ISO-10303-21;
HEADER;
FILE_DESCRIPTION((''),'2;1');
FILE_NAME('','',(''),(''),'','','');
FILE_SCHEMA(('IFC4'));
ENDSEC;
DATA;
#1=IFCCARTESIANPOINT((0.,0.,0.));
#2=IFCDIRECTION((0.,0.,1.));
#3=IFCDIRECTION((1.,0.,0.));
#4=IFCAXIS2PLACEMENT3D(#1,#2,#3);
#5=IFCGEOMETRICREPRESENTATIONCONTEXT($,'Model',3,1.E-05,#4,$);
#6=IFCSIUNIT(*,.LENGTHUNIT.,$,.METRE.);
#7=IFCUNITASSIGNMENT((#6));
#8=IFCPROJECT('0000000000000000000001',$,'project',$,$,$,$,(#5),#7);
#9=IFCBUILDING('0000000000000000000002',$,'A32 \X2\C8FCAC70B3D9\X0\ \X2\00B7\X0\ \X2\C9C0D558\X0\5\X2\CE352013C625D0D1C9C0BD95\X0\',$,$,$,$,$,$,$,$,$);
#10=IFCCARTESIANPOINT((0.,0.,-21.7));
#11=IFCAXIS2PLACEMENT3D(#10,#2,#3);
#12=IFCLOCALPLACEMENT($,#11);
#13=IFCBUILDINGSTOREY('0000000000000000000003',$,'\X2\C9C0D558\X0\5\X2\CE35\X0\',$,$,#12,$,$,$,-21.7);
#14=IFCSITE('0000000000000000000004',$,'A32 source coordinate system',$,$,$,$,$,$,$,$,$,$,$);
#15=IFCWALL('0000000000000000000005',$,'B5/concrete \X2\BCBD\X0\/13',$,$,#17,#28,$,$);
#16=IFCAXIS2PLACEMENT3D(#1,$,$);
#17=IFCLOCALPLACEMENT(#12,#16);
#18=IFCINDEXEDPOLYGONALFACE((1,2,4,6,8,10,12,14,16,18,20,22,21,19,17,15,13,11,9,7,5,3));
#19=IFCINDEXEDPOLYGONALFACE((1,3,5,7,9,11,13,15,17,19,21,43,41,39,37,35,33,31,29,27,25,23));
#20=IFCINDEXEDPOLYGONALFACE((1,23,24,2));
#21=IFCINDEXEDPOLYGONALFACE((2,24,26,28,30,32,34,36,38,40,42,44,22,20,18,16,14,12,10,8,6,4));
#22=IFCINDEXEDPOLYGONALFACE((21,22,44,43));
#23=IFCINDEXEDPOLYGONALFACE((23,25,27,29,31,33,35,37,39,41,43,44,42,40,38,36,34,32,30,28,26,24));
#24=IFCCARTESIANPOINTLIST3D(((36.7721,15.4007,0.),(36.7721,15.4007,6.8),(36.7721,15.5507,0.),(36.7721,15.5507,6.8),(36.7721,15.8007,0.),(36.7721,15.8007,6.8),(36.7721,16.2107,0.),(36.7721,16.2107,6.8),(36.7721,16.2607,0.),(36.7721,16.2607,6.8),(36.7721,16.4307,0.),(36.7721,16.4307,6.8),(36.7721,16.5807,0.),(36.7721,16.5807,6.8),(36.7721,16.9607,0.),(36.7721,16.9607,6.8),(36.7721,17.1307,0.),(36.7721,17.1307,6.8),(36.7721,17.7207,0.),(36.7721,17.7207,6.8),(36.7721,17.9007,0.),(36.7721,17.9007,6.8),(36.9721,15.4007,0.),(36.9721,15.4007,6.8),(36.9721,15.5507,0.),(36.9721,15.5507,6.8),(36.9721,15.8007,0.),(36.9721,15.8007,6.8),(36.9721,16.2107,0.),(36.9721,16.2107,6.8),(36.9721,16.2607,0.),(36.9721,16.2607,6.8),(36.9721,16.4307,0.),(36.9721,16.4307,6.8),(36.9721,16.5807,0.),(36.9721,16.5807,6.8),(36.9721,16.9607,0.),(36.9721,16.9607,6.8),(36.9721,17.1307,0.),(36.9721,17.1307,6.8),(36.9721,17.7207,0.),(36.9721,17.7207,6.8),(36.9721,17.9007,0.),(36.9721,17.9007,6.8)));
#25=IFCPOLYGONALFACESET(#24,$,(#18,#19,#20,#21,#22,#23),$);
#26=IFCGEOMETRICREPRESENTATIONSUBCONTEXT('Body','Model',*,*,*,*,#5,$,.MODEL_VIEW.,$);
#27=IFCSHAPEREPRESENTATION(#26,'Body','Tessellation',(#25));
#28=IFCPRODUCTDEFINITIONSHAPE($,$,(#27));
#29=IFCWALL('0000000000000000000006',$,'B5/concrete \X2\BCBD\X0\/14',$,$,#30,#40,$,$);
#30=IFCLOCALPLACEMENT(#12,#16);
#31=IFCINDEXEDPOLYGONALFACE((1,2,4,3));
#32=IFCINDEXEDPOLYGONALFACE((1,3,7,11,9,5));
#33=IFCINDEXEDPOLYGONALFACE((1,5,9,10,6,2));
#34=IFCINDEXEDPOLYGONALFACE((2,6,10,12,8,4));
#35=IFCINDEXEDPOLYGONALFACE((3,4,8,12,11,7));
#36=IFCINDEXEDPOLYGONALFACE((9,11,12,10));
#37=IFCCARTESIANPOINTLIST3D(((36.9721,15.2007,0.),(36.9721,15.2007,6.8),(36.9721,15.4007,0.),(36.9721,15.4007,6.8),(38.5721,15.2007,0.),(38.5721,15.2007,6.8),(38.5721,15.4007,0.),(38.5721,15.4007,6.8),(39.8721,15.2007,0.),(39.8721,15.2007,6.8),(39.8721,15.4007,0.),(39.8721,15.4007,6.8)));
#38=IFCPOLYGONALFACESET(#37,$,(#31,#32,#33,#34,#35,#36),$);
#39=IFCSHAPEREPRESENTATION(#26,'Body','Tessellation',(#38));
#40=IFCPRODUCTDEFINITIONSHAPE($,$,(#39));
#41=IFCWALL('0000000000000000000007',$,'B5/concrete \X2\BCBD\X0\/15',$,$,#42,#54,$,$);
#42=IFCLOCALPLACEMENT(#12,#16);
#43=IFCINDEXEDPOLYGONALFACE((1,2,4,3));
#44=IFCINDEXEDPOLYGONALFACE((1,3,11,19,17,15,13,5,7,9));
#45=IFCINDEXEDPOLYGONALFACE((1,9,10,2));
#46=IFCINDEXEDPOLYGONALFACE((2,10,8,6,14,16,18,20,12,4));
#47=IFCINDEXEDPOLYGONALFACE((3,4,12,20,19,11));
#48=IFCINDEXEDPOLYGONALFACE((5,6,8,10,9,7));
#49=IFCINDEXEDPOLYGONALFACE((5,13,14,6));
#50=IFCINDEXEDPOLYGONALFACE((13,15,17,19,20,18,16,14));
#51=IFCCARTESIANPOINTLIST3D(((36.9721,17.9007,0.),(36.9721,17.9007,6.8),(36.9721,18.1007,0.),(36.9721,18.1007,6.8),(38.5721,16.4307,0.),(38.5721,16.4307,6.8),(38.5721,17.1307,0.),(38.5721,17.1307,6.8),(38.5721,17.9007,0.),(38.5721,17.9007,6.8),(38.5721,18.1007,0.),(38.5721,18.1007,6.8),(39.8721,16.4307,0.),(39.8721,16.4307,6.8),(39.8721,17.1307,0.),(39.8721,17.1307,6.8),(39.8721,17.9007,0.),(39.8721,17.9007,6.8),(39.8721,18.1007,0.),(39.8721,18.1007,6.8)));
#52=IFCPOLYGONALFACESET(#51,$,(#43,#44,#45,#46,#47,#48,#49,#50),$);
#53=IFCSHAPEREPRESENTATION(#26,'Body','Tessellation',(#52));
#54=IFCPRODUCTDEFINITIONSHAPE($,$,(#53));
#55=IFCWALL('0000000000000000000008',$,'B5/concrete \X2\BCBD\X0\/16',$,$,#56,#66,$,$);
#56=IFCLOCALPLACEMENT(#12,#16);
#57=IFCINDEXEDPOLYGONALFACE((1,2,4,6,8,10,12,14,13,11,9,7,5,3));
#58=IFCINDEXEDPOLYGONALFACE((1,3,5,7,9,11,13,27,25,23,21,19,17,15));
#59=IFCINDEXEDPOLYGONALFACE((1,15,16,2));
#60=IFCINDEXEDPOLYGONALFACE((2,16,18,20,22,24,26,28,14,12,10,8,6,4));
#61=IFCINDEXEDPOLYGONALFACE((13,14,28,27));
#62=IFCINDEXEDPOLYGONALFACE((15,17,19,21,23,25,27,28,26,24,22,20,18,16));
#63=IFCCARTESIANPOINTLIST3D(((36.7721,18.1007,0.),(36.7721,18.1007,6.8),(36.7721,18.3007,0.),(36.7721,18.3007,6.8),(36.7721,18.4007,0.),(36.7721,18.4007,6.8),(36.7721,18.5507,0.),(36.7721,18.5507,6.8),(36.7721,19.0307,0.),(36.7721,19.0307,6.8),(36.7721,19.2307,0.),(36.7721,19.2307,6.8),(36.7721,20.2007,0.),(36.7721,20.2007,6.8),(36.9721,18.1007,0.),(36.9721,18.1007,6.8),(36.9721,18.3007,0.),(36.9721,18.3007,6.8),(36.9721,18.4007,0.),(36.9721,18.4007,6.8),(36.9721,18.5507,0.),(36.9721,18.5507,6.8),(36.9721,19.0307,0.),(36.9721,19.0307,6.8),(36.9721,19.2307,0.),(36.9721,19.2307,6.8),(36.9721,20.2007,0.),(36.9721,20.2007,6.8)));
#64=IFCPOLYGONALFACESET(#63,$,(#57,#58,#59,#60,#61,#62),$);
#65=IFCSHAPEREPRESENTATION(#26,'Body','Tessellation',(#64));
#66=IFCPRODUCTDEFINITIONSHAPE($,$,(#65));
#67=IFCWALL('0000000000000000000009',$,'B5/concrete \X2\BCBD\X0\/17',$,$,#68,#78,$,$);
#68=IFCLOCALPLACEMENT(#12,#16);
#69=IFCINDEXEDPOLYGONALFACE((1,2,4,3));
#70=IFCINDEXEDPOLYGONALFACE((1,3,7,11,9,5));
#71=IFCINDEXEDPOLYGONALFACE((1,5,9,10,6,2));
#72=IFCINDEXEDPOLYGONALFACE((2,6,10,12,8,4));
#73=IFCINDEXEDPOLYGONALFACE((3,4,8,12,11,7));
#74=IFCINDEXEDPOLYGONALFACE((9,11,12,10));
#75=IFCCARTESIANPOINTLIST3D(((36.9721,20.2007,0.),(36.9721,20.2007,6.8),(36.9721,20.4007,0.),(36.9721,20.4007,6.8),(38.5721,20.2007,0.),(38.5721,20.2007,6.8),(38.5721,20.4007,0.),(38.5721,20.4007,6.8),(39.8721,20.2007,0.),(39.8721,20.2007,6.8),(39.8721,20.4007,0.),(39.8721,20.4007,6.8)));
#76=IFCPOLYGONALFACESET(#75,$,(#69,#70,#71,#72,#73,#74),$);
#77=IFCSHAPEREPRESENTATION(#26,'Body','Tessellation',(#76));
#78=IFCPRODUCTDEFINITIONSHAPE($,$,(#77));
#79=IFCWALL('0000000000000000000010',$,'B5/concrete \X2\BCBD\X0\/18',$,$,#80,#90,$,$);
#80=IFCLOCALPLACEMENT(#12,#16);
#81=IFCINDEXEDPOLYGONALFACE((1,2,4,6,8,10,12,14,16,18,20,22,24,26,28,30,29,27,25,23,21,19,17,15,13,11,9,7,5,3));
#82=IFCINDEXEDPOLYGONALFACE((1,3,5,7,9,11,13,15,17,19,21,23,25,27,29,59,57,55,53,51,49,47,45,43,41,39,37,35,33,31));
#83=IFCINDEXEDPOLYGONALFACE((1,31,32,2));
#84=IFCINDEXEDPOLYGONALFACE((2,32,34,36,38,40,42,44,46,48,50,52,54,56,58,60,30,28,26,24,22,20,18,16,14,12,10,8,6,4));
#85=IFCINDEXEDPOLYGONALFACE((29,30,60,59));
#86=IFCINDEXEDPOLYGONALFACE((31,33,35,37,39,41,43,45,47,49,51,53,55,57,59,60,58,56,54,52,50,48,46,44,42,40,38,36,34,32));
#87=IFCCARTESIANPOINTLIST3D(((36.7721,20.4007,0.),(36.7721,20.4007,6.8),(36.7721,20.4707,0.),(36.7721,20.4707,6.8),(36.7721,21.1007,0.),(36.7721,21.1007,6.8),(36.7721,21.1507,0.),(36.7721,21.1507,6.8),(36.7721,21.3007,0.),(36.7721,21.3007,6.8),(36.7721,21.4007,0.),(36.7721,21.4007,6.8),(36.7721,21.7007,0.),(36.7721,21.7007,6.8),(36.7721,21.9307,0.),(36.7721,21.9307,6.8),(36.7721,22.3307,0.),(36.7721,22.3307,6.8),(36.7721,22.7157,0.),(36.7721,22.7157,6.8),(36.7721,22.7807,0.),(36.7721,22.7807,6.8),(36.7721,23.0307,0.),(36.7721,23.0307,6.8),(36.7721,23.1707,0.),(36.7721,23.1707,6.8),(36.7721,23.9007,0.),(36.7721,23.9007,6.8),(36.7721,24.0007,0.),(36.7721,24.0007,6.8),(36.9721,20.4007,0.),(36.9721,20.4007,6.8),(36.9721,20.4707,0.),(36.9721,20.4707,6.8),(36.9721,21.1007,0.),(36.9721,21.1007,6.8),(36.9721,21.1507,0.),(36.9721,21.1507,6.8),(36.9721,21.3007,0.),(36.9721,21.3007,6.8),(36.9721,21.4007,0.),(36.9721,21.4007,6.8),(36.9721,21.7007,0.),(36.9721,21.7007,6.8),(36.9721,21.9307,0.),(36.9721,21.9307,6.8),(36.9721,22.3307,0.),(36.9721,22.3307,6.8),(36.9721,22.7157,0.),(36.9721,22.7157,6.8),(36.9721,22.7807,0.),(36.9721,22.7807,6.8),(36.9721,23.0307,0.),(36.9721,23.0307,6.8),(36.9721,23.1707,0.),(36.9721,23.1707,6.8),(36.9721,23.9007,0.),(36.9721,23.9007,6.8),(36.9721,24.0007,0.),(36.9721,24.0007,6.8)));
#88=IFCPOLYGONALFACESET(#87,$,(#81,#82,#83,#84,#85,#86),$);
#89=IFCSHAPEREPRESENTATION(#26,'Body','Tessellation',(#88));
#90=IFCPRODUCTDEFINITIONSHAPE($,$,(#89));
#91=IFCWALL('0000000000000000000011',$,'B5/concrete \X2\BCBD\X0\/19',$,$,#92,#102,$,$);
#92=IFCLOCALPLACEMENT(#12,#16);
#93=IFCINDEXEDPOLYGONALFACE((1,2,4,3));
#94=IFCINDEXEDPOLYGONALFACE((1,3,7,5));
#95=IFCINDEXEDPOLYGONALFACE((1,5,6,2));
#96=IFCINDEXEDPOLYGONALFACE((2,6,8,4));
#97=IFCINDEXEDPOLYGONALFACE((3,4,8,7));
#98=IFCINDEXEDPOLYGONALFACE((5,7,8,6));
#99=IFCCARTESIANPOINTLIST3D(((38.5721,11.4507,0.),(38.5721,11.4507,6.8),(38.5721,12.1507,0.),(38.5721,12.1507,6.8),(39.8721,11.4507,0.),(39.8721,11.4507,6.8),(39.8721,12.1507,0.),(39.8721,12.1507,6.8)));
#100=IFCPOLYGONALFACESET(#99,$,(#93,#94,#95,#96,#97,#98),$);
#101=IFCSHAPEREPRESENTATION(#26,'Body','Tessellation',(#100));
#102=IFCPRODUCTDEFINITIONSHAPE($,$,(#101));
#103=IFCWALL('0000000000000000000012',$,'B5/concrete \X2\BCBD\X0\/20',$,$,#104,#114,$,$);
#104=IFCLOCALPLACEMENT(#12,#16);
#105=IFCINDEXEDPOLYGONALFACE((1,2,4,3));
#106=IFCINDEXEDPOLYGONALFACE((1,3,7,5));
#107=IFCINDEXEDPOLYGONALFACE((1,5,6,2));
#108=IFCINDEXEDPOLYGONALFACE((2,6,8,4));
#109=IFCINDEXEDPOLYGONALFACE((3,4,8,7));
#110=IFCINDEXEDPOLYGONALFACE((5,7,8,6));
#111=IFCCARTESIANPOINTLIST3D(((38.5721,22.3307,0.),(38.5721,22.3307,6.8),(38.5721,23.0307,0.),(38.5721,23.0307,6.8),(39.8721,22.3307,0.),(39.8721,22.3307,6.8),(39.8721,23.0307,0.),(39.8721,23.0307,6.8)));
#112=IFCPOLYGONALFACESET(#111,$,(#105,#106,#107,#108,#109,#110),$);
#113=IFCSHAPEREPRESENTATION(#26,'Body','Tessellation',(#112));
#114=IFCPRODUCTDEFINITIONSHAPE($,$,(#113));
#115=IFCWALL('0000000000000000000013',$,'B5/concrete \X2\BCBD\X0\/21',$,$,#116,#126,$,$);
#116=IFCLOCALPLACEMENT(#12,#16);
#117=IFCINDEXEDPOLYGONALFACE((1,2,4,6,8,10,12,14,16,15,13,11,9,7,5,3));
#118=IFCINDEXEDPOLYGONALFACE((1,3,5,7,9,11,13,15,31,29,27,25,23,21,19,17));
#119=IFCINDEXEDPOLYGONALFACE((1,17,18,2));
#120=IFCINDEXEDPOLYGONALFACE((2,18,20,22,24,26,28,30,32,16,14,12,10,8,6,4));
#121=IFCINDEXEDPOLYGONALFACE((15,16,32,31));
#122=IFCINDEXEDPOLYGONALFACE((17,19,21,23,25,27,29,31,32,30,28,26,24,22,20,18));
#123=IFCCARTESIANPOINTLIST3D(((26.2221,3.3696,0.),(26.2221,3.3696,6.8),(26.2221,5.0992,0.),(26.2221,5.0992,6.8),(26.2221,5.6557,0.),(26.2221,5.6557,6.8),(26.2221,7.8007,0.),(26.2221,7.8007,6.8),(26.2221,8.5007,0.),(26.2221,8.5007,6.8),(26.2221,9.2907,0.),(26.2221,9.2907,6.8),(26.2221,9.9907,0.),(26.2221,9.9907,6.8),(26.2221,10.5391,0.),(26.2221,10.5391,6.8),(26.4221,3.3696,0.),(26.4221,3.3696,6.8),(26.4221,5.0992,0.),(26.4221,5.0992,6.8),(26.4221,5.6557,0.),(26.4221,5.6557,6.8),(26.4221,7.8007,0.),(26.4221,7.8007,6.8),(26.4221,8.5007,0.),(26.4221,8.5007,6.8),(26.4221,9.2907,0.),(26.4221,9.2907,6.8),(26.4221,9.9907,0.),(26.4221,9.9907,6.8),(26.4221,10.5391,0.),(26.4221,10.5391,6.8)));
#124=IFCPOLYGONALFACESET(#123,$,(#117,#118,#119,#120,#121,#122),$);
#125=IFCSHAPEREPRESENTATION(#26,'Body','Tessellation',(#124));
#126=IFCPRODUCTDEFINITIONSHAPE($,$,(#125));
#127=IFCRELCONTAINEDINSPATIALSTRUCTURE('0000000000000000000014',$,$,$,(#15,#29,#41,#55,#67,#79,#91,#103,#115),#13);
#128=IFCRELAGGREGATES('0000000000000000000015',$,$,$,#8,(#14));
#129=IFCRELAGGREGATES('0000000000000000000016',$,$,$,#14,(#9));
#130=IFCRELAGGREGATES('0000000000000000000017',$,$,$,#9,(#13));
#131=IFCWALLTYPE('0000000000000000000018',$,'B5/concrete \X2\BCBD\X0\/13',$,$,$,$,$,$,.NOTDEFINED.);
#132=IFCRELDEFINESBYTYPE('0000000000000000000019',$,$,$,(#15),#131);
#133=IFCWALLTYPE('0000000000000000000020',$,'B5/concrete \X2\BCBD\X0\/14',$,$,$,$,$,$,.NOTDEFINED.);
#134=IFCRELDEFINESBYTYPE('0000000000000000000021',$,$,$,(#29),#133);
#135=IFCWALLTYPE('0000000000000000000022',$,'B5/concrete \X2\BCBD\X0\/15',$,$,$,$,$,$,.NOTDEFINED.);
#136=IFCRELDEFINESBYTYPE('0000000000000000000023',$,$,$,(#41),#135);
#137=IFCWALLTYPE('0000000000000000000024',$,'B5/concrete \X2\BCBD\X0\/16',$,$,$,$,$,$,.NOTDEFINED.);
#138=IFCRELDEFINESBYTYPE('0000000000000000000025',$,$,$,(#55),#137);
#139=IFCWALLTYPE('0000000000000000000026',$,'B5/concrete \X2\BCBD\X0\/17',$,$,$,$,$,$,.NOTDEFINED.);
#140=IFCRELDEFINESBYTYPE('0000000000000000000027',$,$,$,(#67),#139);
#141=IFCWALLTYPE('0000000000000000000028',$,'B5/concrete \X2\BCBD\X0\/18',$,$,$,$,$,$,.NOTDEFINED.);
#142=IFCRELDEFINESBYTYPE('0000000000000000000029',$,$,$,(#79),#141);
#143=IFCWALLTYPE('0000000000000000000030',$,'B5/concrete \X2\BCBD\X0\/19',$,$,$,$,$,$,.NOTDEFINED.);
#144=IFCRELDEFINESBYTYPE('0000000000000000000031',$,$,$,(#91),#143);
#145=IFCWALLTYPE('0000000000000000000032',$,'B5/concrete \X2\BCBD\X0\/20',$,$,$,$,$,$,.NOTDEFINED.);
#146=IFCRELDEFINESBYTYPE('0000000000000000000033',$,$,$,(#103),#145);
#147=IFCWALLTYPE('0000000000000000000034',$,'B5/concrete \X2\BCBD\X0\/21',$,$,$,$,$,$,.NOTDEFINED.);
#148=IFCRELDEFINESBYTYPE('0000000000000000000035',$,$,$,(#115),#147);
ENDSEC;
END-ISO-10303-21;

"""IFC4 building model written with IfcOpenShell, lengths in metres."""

from ifc_helpers import new_model, si_unit, frame, origin, origin_with_axes, place, context, subcontext, project, spatial, polyline, outline, extrude, source, transform, mapped, type_object, type_shapes, element, save


model = new_model("IFC4")

# Units and contexts
model_context = context("Model", 3, precision=1e-05, world=origin_with_axes())
body_context = subcontext(model_context, "Body", "Model", "MODEL_VIEW")
ifc_project = project(units=[si_unit("LENGTHUNIT", "METRE")], contexts=[model_context])

# Site, building, storey
site = spatial("IfcSite", under=ifc_project, Name="A32 source coordinate system")
building = spatial("IfcBuilding", under=site, Name="A32 주거동 · 지하5층–옥탑지붕")
storey_placement = place(None, frame((0.0, 0.0, -21.7), z_axis=(0.0, 0.0, 1.0), x_axis=(1.0, 0.0, 0.0)))
storey = spatial("IfcBuildingStorey", under=building, at=storey_placement, Name="지하5층", Elevation=-21.7)

# Walls
wall_type_1 = type_object("IfcWallType", Name="B5/concrete 벽/13", PredefinedType="NOTDEFINED")
shared_shape_1 = source(origin(), body_context, "Body", "SweptSolid", [
    extrude(outline(polyline([(36.9721, 17.1307), (36.9721, 16.9607), (36.9721, 16.5807), (36.9721, 16.4307), (36.9721, 16.2607), (36.9721, 16.2107), (36.9721, 15.8007), (36.9721, 15.5507), (36.9721, 15.4007), (36.7721, 15.4007), (36.7721, 15.5507), (36.7721, 15.8007), (36.7721, 16.2107), (36.7721, 16.2607), (36.7721, 16.4307), (36.7721, 16.5807), (36.7721, 16.9607), (36.7721, 17.1307), (36.7721, 17.7207), (36.7721, 17.9007), (36.9721, 17.9007), (36.9721, 17.7207), (36.9721, 17.1307)])), origin(), (0.0, 0.0, 1.0), 6.8),
])
type_shapes(wall_type_1, [shared_shape_1])
wall_1_placement = place(storey_placement, origin_with_axes())
element("IfcWall", 1, at=wall_1_placement, inside=storey, type_object=wall_type_1, Name="B5/concrete 벽/13", context=body_context, shape_type="MappedRepresentation", body=[
    mapped(shared_shape_1, transform((0.0, 0.0, 0.0), scale=1.0)),
])
wall_type_2 = type_object("IfcWallType", Name="B5/concrete 벽/14", PredefinedType="NOTDEFINED")
shared_shape_2 = source(origin(), body_context, "Body", "SweptSolid", [
    extrude(outline(polyline([(39.8721, 15.2007), (38.5721, 15.2007), (36.9721, 15.2007), (36.9721, 15.4007), (38.5721, 15.4007), (39.8721, 15.4007), (39.8721, 15.2007)])), origin(), (0.0, 0.0, 1.0), 6.8),
])
type_shapes(wall_type_2, [shared_shape_2])
wall_2_placement = place(storey_placement, origin_with_axes())
element("IfcWall", 2, at=wall_2_placement, inside=storey, type_object=wall_type_2, Name="B5/concrete 벽/14", context=body_context, shape_type="MappedRepresentation", body=[
    mapped(shared_shape_2, transform((0.0, 0.0, 0.0), scale=1.0)),
])
wall_type_3 = type_object("IfcWallType", Name="B5/concrete 벽/15", PredefinedType="NOTDEFINED")
shared_shape_3 = source(origin(), body_context, "Body", "SweptSolid", [
    extrude(outline(polyline([(39.8721, 18.1007), (39.8721, 17.9007), (39.8721, 17.1307), (39.8721, 16.4307), (38.5721, 16.4307), (38.5721, 17.1307), (38.5721, 17.9007), (36.9721, 17.9007), (36.9721, 18.1007), (38.5721, 18.1007), (39.8721, 18.1007)])), origin(), (0.0, 0.0, 1.0), 6.8),
])
type_shapes(wall_type_3, [shared_shape_3])
wall_3_placement = place(storey_placement, origin_with_axes())
element("IfcWall", 3, at=wall_3_placement, inside=storey, type_object=wall_type_3, Name="B5/concrete 벽/15", context=body_context, shape_type="MappedRepresentation", body=[
    mapped(shared_shape_3, transform((0.0, 0.0, 0.0), scale=1.0)),
])
wall_type_4 = type_object("IfcWallType", Name="B5/concrete 벽/16", PredefinedType="NOTDEFINED")
shared_shape_4 = source(origin(), body_context, "Body", "SweptSolid", [
    extrude(outline(polyline([(36.7721, 18.4007), (36.7721, 18.5507), (36.7721, 19.0307), (36.7721, 19.2307), (36.7721, 20.2007), (36.9721, 20.2007), (36.9721, 19.2307), (36.9721, 19.0307), (36.9721, 18.5507), (36.9721, 18.4007), (36.9721, 18.3007), (36.9721, 18.1007), (36.7721, 18.1007), (36.7721, 18.3007), (36.7721, 18.4007)])), origin(), (0.0, 0.0, 1.0), 6.8),
])
type_shapes(wall_type_4, [shared_shape_4])
wall_4_placement = place(storey_placement, origin_with_axes())
element("IfcWall", 4, at=wall_4_placement, inside=storey, type_object=wall_type_4, Name="B5/concrete 벽/16", context=body_context, shape_type="MappedRepresentation", body=[
    mapped(shared_shape_4, transform((0.0, 0.0, 0.0), scale=1.0)),
])
wall_type_5 = type_object("IfcWallType", Name="B5/concrete 벽/17", PredefinedType="NOTDEFINED")
shared_shape_5 = source(origin(), body_context, "Body", "SweptSolid", [
    extrude(outline(polyline([(39.8721, 20.4007), (39.8721, 20.2007), (38.5721, 20.2007), (36.9721, 20.2007), (36.9721, 20.4007), (38.5721, 20.4007), (39.8721, 20.4007)])), origin(), (0.0, 0.0, 1.0), 6.8),
])
type_shapes(wall_type_5, [shared_shape_5])
wall_5_placement = place(storey_placement, origin_with_axes())
element("IfcWall", 5, at=wall_5_placement, inside=storey, type_object=wall_type_5, Name="B5/concrete 벽/17", context=body_context, shape_type="MappedRepresentation", body=[
    mapped(shared_shape_5, transform((0.0, 0.0, 0.0), scale=1.0)),
])
wall_type_6 = type_object("IfcWallType", Name="B5/concrete 벽/18", PredefinedType="NOTDEFINED")
shared_shape_6 = source(origin(), body_context, "Body", "SweptSolid", [
    extrude(outline(polyline([(36.7721, 21.1007), (36.7721, 21.1507), (36.7721, 21.3007), (36.7721, 21.4007), (36.7721, 21.7007), (36.7721, 21.9307), (36.7721, 22.3307), (36.7721, 22.7157), (36.7721, 22.7807), (36.7721, 23.0307), (36.7721, 23.1707), (36.7721, 23.9007), (36.7721, 24.0007), (36.9721, 24.0007), (36.9721, 23.9007), (36.9721, 23.1707), (36.9721, 23.0307), (36.9721, 22.7807), (36.9721, 22.7157), (36.9721, 22.3307), (36.9721, 21.9307), (36.9721, 21.7007), (36.9721, 21.4007), (36.9721, 21.3007), (36.9721, 21.1507), (36.9721, 21.1007), (36.9721, 20.4707), (36.9721, 20.4007), (36.7721, 20.4007), (36.7721, 20.4707), (36.7721, 21.1007)])), origin(), (0.0, 0.0, 1.0), 6.8),
])
type_shapes(wall_type_6, [shared_shape_6])
wall_6_placement = place(storey_placement, origin_with_axes())
element("IfcWall", 6, at=wall_6_placement, inside=storey, type_object=wall_type_6, Name="B5/concrete 벽/18", context=body_context, shape_type="MappedRepresentation", body=[
    mapped(shared_shape_6, transform((0.0, 0.0, 0.0), scale=1.0)),
])
wall_type_7 = type_object("IfcWallType", Name="B5/concrete 벽/19", PredefinedType="NOTDEFINED")
shared_shape_7 = source(origin(), body_context, "Body", "SweptSolid", [
    extrude(outline(polyline([(39.8721, 11.4507), (38.5721, 11.4507), (38.5721, 12.1507), (39.8721, 12.1507), (39.8721, 11.4507)])), origin(), (0.0, 0.0, 1.0), 6.8),
])
type_shapes(wall_type_7, [shared_shape_7])
wall_7_placement = place(storey_placement, origin_with_axes())
element("IfcWall", 7, at=wall_7_placement, inside=storey, type_object=wall_type_7, Name="B5/concrete 벽/19", context=body_context, shape_type="MappedRepresentation", body=[
    mapped(shared_shape_7, transform((0.0, 0.0, 0.0), scale=1.0)),
])
wall_type_8 = type_object("IfcWallType", Name="B5/concrete 벽/20", PredefinedType="NOTDEFINED")
shared_shape_8 = source(origin(), body_context, "Body", "SweptSolid", [
    extrude(outline(polyline([(39.8721, 22.3307), (38.5721, 22.3307), (38.5721, 23.0307), (39.8721, 23.0307), (39.8721, 22.3307)])), origin(), (0.0, 0.0, 1.0), 6.8),
])
type_shapes(wall_type_8, [shared_shape_8])
wall_8_placement = place(storey_placement, origin_with_axes())
element("IfcWall", 8, at=wall_8_placement, inside=storey, type_object=wall_type_8, Name="B5/concrete 벽/20", context=body_context, shape_type="MappedRepresentation", body=[
    mapped(shared_shape_8, transform((0.0, 0.0, 0.0), scale=1.0)),
])
wall_type_9 = type_object("IfcWallType", Name="B5/concrete 벽/21", PredefinedType="NOTDEFINED")
shared_shape_9 = source(origin(), body_context, "Body", "SweptSolid", [
    extrude(outline(polyline([(26.4221, 9.2907), (26.4221, 8.5007), (26.4221, 7.8007), (26.4221, 5.6557), (26.4221, 5.0992), (26.4221, 3.3696), (26.2221, 3.3696), (26.2221, 5.0992), (26.2221, 5.6557), (26.2221, 7.8007), (26.2221, 8.5007), (26.2221, 9.2907), (26.2221, 9.9907), (26.2221, 10.5391), (26.4221, 10.5391), (26.4221, 9.9907), (26.4221, 9.2907)])), origin(), (0.0, 0.0, 1.0), 6.8),
])
type_shapes(wall_type_9, [shared_shape_9])
wall_9_placement = place(storey_placement, origin_with_axes())
element("IfcWall", 9, at=wall_9_placement, inside=storey, type_object=wall_type_9, Name="B5/concrete 벽/21", context=body_context, shape_type="MappedRepresentation", body=[
    mapped(shared_shape_9, transform((0.0, 0.0, 0.0), scale=1.0)),
])

save(model, "model.ifc")
